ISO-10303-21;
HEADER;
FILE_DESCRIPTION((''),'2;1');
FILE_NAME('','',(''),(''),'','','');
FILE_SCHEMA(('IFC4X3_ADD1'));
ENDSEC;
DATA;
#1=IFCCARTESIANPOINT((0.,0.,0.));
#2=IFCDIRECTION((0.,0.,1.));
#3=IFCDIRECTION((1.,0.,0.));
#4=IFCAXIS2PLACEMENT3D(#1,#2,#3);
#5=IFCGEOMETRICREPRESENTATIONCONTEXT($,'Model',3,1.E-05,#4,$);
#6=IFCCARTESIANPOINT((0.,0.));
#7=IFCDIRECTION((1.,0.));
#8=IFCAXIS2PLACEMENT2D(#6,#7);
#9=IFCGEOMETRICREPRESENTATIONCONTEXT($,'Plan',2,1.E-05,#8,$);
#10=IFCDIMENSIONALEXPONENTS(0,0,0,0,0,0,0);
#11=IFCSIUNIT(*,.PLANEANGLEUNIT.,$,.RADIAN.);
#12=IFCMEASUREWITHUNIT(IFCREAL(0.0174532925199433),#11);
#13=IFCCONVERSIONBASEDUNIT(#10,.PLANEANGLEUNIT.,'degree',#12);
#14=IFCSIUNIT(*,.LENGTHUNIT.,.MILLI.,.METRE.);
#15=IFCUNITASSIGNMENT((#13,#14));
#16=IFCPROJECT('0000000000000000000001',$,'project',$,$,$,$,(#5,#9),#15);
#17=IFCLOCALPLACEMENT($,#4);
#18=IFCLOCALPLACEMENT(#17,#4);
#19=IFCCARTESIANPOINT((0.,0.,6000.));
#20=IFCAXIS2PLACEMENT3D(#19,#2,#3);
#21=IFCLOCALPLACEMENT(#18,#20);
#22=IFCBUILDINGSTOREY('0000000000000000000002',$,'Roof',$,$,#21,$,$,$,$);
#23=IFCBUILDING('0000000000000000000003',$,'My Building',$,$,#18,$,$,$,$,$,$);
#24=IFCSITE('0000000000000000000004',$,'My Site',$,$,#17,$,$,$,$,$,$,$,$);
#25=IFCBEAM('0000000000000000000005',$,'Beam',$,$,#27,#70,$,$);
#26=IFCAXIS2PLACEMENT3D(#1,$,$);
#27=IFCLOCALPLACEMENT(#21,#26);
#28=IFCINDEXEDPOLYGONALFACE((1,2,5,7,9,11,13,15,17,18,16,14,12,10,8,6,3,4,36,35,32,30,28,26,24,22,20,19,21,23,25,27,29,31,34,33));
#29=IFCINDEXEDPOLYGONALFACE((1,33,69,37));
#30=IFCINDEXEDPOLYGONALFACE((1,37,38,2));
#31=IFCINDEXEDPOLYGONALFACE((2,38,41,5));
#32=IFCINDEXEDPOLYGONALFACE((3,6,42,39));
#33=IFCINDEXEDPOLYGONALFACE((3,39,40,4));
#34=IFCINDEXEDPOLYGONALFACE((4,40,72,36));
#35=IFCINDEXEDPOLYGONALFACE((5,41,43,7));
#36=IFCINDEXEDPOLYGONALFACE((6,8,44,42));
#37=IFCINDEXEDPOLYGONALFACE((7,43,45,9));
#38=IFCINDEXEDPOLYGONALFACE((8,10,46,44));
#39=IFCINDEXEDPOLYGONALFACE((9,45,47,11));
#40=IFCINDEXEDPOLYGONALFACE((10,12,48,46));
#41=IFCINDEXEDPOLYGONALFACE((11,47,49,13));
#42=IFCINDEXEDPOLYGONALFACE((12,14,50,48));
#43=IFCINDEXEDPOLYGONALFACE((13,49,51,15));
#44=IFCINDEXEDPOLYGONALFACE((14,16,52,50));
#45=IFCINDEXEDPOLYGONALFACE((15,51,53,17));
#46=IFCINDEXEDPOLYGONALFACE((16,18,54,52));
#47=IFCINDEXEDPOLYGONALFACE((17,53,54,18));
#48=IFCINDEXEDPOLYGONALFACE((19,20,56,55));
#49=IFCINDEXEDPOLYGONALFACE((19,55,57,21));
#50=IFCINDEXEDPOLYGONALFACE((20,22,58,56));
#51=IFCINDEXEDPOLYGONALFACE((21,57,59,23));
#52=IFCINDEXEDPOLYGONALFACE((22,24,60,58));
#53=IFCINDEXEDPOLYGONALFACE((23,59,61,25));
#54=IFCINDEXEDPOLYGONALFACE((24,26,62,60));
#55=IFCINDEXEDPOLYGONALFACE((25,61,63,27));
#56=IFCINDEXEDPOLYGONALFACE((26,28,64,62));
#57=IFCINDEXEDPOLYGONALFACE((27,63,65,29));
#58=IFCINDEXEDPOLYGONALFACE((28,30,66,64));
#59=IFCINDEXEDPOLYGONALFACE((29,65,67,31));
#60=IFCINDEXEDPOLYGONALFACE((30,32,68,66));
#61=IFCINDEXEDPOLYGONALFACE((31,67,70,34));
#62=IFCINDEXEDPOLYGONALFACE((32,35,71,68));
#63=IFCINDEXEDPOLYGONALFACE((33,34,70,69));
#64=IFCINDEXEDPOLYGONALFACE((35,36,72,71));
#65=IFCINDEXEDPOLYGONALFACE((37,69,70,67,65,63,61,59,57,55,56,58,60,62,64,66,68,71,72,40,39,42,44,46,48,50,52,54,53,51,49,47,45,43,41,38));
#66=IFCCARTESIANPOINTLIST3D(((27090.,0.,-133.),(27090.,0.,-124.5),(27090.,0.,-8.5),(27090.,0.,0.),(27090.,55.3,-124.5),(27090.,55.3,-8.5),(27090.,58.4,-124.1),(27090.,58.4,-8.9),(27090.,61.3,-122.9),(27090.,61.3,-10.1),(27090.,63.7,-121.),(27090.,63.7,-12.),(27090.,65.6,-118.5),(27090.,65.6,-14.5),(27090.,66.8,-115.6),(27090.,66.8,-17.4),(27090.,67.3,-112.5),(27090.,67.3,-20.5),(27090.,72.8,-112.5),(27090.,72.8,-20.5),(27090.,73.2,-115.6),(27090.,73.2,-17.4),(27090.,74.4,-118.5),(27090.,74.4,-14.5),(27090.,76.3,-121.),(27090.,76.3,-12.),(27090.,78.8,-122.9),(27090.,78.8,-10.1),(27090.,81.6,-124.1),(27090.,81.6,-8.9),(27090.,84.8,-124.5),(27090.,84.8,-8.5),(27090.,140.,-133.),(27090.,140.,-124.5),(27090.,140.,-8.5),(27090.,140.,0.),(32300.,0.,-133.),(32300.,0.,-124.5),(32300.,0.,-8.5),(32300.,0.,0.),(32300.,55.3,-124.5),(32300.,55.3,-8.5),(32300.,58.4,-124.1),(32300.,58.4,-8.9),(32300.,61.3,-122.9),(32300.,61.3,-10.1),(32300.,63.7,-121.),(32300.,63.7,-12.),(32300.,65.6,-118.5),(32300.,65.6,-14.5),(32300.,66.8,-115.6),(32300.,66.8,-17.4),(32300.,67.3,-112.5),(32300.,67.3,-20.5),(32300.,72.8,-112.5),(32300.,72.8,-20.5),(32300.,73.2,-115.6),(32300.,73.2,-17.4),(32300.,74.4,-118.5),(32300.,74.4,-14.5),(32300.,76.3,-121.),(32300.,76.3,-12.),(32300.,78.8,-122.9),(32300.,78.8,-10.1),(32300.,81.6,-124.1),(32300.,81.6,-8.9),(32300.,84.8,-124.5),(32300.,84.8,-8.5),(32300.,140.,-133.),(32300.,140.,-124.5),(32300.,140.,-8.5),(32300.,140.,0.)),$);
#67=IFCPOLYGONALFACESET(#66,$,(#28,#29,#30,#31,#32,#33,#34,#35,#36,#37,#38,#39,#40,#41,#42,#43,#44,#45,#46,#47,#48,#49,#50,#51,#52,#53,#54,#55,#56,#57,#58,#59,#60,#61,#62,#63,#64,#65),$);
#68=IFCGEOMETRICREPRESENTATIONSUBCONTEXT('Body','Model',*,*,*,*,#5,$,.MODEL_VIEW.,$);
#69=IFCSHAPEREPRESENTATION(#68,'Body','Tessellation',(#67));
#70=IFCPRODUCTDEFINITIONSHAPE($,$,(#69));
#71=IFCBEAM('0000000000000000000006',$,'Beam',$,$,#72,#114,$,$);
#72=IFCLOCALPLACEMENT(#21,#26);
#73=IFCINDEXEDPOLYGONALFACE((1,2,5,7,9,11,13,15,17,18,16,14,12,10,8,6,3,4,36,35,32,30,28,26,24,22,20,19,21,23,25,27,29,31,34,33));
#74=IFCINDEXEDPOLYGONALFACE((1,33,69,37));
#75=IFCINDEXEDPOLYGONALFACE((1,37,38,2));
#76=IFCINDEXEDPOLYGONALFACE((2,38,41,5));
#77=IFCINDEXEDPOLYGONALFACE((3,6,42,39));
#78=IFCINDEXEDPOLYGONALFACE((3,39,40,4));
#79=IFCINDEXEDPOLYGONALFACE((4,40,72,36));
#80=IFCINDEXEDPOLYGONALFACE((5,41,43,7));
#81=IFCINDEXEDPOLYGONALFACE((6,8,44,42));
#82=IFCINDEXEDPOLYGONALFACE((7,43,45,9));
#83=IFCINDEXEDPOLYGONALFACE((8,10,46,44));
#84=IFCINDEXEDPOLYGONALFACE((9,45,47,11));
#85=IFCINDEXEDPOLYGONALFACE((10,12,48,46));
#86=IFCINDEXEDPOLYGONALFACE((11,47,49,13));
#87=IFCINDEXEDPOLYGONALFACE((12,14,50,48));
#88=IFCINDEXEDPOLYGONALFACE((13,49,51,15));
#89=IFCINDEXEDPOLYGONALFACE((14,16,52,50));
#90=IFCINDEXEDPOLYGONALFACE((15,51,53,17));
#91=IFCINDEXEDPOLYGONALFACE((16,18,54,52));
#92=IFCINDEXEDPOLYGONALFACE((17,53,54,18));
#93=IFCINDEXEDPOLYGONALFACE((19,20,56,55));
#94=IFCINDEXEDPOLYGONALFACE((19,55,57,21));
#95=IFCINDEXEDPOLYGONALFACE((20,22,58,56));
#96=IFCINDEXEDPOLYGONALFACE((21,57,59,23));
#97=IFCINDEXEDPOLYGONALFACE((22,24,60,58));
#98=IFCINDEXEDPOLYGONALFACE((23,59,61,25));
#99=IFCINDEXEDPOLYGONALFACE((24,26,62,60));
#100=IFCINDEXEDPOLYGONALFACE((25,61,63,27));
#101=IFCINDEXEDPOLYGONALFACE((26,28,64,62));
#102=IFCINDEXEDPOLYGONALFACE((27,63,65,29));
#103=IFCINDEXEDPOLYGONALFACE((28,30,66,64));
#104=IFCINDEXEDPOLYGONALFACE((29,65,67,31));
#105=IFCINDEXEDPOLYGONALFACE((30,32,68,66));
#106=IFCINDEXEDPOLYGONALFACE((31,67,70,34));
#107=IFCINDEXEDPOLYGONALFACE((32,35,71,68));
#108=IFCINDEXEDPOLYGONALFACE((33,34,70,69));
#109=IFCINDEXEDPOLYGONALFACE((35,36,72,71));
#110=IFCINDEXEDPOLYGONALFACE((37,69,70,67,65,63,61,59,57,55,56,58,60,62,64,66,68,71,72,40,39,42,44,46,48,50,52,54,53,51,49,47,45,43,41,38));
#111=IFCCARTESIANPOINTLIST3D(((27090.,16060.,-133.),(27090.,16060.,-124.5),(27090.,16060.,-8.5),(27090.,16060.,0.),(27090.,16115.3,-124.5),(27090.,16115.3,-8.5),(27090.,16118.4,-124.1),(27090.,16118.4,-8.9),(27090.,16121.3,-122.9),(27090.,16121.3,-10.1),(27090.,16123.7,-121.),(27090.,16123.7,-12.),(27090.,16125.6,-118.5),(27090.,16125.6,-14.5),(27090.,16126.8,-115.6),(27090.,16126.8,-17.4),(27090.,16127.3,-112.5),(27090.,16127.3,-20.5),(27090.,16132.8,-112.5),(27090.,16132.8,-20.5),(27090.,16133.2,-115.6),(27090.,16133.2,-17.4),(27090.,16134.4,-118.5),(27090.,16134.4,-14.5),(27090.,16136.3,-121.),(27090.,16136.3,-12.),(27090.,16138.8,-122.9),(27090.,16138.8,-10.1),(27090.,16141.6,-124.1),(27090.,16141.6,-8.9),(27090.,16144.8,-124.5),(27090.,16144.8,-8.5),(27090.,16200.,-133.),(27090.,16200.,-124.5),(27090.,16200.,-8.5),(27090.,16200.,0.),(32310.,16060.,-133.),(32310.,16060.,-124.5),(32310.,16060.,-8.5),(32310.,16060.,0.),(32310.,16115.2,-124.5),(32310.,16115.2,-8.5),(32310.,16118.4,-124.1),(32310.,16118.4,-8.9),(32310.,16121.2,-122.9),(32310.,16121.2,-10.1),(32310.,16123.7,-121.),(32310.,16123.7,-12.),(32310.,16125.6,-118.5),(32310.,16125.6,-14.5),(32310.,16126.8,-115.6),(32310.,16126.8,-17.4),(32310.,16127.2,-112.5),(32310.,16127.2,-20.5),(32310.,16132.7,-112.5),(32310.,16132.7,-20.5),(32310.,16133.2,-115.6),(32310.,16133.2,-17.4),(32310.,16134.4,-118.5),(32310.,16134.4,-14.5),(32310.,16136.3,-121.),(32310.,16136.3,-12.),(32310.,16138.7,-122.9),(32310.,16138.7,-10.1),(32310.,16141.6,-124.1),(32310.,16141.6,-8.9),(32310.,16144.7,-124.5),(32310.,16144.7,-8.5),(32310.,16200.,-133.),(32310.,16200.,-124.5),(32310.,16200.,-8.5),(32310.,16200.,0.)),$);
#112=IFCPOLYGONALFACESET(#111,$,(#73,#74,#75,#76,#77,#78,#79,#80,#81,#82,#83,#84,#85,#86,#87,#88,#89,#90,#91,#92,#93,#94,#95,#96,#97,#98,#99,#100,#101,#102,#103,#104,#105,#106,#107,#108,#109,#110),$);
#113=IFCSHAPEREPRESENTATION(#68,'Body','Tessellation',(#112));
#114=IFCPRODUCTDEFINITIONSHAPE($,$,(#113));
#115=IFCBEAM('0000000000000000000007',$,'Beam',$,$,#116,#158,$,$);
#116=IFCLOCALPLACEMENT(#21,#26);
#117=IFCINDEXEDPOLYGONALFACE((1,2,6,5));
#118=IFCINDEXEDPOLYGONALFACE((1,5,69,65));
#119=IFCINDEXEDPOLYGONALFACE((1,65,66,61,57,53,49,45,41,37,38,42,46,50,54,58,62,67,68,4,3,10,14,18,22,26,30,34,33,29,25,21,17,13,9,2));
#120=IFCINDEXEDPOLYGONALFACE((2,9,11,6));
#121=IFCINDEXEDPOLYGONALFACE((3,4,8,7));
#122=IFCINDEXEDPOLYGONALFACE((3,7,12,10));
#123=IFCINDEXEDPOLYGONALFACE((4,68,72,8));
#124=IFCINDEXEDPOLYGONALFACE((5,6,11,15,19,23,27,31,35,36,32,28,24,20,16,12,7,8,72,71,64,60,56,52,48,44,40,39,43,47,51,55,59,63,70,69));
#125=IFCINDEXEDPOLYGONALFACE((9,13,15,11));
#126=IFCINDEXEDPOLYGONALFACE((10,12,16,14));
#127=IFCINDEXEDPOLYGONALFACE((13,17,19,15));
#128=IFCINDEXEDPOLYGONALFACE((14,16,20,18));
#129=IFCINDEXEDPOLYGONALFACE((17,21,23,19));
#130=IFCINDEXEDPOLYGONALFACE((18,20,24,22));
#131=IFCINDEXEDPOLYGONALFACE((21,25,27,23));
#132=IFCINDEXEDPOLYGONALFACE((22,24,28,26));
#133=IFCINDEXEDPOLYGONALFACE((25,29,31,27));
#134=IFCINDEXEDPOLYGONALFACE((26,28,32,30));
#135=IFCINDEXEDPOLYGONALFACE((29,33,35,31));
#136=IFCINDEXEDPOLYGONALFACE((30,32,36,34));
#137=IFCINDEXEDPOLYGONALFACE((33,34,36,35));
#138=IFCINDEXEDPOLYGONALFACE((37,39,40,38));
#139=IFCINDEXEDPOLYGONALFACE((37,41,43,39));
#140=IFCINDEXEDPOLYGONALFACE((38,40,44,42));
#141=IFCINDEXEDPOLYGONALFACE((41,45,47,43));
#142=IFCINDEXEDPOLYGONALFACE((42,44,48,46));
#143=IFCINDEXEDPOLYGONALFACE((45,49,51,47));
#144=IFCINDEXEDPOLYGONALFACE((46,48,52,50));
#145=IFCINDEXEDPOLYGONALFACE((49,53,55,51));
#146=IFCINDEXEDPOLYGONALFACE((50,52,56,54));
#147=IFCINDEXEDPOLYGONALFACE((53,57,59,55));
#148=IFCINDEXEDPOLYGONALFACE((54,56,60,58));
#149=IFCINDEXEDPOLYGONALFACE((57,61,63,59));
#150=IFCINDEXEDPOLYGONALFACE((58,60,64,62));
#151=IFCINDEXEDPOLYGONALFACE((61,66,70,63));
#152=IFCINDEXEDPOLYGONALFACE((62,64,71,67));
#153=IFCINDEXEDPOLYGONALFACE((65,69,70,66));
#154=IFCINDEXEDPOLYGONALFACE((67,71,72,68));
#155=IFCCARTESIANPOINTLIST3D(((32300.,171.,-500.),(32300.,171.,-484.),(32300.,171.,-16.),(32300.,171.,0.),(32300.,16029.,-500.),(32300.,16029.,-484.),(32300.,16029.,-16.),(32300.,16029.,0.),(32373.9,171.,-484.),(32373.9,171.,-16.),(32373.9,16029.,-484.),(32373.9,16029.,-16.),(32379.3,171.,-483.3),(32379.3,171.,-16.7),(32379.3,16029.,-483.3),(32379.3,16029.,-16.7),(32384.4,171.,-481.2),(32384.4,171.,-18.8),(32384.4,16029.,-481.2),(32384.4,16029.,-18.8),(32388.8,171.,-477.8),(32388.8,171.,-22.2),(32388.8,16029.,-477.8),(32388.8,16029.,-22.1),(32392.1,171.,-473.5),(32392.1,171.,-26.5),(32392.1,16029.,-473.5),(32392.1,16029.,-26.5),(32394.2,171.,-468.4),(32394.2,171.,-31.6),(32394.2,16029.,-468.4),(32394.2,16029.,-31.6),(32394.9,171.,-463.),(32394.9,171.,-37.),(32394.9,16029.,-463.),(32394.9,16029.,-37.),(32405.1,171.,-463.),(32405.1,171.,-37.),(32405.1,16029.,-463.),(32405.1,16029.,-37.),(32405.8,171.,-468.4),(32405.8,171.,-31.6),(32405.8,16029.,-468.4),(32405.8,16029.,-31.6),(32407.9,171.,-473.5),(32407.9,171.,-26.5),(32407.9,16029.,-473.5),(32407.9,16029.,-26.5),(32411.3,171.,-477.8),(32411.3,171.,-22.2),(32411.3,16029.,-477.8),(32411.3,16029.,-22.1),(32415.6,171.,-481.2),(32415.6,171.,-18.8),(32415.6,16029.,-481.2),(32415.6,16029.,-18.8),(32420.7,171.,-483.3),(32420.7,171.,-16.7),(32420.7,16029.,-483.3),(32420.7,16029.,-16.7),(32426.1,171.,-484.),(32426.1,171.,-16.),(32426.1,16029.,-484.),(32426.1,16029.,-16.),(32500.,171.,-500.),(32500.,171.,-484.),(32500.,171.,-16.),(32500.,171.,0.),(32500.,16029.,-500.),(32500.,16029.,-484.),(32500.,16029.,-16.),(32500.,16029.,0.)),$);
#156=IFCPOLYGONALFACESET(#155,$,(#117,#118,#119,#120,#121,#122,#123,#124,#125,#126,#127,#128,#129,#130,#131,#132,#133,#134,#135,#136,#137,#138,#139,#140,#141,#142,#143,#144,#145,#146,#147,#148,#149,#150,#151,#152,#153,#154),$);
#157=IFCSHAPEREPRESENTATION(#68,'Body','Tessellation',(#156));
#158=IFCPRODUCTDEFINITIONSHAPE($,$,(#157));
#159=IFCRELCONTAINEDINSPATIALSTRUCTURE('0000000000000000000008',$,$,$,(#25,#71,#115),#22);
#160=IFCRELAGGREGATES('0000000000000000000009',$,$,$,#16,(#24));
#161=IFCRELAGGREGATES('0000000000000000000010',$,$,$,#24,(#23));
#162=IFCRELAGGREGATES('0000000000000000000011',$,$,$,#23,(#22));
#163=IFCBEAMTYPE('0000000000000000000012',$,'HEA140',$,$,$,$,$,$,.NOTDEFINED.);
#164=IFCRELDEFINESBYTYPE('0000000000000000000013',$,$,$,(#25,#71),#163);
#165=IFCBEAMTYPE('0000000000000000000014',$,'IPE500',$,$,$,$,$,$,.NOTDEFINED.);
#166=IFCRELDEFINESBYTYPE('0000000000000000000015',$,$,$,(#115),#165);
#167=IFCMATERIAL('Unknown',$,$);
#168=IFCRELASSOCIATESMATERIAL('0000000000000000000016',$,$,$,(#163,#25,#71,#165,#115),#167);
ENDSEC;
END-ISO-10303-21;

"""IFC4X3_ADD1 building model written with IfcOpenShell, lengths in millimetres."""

from ifc_helpers import new_model, entity, si_unit, converted_unit, frame, origin_with_axes, origin_2d_with_axis, place, context, subcontext, project, spatial, i_section, extrude, material, material_profile, profile_set, profile_usage, type_object, element, save


model = new_model("IFC4X3_ADD1")

# Units and contexts
model_context = context("Model", 3, precision=1e-05, world=origin_with_axes())
plan_context = context("Plan", 2, precision=1e-05, world=origin_2d_with_axis())
body_context = subcontext(model_context, "Body", "Model", "MODEL_VIEW")
ifc_project = project(units=[converted_unit("PLANEANGLEUNIT", "degree", entity("IfcReal", 0.0174532925199433), si_unit("PLANEANGLEUNIT", "RADIAN"), dimensions=[0, 0, 0, 0, 0, 0, 0]), si_unit("LENGTHUNIT", "METRE", prefix="MILLI")], contexts=[model_context, plan_context])

# Site, building, storey
site_placement = place(None, origin_with_axes())
site = spatial("IfcSite", under=ifc_project, at=site_placement, Name="My Site")
building_placement = place(site_placement, origin_with_axes())
building = spatial("IfcBuilding", under=site, at=building_placement, Name="My Building")
storey_placement = place(building_placement, frame((0.0, 0.0, 6000.0), z_axis=(0.0, 0.0, 1.0), x_axis=(1.0, 0.0, 0.0)))
storey = spatial("IfcBuildingStorey", under=building, at=storey_placement, Name="Roof")

# Beams
ifc_material = material(Name="Unknown")
ifc_material_profile_1 = material_profile(ifc_material, i_section(OverallWidth=140.0, OverallDepth=133.0, WebThickness=5.5, FlangeThickness=8.5, FilletRadius=12.0))
ifc_profile_set_1 = profile_set([ifc_material_profile_1])
beam_type_1 = type_object("IfcBeamType", Name="HEA140", PredefinedType="NOTDEFINED", material=ifc_profile_set_1)
ifc_profile_usage_1 = profile_usage(ifc_profile_set_1, cardinal=7)
beam_1_placement = place(storey_placement, frame((32300.0, 0.0, 0.0), z_axis=(-1.0, 0.0, 0.0), x_axis=(0.0, -1.0, 0.0)))
element("IfcBeam", 1, at=beam_1_placement, inside=storey, type_object=beam_type_1, material=ifc_profile_usage_1, Name="Beam", context=body_context, shape_type="SweptSolid", body=[
    extrude(i_section(OverallWidth=140.0, OverallDepth=133.0, WebThickness=5.5, FlangeThickness=8.5, FilletRadius=12.0), frame((-70.0, -66.5, 0.0), z_axis=(0.0, 0.0, 1.0), x_axis=(1.0, 0.0, 0.0)), (0.0, 0.0, 1.0), 5210.0),
])
ifc_profile_usage_2 = profile_usage(ifc_profile_set_1, cardinal=7)
beam_2_placement = place(storey_placement, frame((27090.0, 16200.0, 0.0), z_axis=(1.0, 0.0, 0.0), x_axis=(0.0, 1.0, 0.0)))
element("IfcBeam", 2, at=beam_2_placement, inside=storey, type_object=beam_type_1, material=ifc_profile_usage_2, Name="Beam", context=body_context, shape_type="SweptSolid", body=[
    extrude(i_section(OverallWidth=140.0, OverallDepth=133.0, WebThickness=5.5, FlangeThickness=8.5, FilletRadius=12.0), frame((-70.0, -66.5, 0.0), z_axis=(0.0, 0.0, 1.0), x_axis=(1.0, 0.0, 0.0)), (0.0, 0.0, 1.0), 5220.0),
])
ifc_material_profile_2 = material_profile(ifc_material, i_section(OverallWidth=200.0, OverallDepth=500.0, WebThickness=10.2, FlangeThickness=16.0, FilletRadius=21.0))
ifc_profile_set_2 = profile_set([ifc_material_profile_2])
ifc_profile_usage_3 = profile_usage(ifc_profile_set_2, cardinal=8)
beam_type_2 = type_object("IfcBeamType", Name="IPE500", PredefinedType="NOTDEFINED", material=ifc_profile_set_2)
beam_3_placement = place(storey_placement, frame((32400.0, 171.0, 0.0), z_axis=(0.0, 1.0, 0.0), x_axis=(-1.0, 0.0, 0.0)))
element("IfcBeam", 3, at=beam_3_placement, inside=storey, type_object=beam_type_2, material=ifc_profile_usage_3, Name="Beam", context=body_context, shape_type="SweptSolid", body=[
    extrude(i_section(OverallWidth=200.0, OverallDepth=500.0, WebThickness=10.2, FlangeThickness=16.0, FilletRadius=21.0), frame((0.0, -250.0, 0.0), z_axis=(0.0, 0.0, 1.0), x_axis=(1.0, 0.0, 0.0)), (0.0, 0.0, 1.0), 15858.0),
])

save(model, "model.ifc")
